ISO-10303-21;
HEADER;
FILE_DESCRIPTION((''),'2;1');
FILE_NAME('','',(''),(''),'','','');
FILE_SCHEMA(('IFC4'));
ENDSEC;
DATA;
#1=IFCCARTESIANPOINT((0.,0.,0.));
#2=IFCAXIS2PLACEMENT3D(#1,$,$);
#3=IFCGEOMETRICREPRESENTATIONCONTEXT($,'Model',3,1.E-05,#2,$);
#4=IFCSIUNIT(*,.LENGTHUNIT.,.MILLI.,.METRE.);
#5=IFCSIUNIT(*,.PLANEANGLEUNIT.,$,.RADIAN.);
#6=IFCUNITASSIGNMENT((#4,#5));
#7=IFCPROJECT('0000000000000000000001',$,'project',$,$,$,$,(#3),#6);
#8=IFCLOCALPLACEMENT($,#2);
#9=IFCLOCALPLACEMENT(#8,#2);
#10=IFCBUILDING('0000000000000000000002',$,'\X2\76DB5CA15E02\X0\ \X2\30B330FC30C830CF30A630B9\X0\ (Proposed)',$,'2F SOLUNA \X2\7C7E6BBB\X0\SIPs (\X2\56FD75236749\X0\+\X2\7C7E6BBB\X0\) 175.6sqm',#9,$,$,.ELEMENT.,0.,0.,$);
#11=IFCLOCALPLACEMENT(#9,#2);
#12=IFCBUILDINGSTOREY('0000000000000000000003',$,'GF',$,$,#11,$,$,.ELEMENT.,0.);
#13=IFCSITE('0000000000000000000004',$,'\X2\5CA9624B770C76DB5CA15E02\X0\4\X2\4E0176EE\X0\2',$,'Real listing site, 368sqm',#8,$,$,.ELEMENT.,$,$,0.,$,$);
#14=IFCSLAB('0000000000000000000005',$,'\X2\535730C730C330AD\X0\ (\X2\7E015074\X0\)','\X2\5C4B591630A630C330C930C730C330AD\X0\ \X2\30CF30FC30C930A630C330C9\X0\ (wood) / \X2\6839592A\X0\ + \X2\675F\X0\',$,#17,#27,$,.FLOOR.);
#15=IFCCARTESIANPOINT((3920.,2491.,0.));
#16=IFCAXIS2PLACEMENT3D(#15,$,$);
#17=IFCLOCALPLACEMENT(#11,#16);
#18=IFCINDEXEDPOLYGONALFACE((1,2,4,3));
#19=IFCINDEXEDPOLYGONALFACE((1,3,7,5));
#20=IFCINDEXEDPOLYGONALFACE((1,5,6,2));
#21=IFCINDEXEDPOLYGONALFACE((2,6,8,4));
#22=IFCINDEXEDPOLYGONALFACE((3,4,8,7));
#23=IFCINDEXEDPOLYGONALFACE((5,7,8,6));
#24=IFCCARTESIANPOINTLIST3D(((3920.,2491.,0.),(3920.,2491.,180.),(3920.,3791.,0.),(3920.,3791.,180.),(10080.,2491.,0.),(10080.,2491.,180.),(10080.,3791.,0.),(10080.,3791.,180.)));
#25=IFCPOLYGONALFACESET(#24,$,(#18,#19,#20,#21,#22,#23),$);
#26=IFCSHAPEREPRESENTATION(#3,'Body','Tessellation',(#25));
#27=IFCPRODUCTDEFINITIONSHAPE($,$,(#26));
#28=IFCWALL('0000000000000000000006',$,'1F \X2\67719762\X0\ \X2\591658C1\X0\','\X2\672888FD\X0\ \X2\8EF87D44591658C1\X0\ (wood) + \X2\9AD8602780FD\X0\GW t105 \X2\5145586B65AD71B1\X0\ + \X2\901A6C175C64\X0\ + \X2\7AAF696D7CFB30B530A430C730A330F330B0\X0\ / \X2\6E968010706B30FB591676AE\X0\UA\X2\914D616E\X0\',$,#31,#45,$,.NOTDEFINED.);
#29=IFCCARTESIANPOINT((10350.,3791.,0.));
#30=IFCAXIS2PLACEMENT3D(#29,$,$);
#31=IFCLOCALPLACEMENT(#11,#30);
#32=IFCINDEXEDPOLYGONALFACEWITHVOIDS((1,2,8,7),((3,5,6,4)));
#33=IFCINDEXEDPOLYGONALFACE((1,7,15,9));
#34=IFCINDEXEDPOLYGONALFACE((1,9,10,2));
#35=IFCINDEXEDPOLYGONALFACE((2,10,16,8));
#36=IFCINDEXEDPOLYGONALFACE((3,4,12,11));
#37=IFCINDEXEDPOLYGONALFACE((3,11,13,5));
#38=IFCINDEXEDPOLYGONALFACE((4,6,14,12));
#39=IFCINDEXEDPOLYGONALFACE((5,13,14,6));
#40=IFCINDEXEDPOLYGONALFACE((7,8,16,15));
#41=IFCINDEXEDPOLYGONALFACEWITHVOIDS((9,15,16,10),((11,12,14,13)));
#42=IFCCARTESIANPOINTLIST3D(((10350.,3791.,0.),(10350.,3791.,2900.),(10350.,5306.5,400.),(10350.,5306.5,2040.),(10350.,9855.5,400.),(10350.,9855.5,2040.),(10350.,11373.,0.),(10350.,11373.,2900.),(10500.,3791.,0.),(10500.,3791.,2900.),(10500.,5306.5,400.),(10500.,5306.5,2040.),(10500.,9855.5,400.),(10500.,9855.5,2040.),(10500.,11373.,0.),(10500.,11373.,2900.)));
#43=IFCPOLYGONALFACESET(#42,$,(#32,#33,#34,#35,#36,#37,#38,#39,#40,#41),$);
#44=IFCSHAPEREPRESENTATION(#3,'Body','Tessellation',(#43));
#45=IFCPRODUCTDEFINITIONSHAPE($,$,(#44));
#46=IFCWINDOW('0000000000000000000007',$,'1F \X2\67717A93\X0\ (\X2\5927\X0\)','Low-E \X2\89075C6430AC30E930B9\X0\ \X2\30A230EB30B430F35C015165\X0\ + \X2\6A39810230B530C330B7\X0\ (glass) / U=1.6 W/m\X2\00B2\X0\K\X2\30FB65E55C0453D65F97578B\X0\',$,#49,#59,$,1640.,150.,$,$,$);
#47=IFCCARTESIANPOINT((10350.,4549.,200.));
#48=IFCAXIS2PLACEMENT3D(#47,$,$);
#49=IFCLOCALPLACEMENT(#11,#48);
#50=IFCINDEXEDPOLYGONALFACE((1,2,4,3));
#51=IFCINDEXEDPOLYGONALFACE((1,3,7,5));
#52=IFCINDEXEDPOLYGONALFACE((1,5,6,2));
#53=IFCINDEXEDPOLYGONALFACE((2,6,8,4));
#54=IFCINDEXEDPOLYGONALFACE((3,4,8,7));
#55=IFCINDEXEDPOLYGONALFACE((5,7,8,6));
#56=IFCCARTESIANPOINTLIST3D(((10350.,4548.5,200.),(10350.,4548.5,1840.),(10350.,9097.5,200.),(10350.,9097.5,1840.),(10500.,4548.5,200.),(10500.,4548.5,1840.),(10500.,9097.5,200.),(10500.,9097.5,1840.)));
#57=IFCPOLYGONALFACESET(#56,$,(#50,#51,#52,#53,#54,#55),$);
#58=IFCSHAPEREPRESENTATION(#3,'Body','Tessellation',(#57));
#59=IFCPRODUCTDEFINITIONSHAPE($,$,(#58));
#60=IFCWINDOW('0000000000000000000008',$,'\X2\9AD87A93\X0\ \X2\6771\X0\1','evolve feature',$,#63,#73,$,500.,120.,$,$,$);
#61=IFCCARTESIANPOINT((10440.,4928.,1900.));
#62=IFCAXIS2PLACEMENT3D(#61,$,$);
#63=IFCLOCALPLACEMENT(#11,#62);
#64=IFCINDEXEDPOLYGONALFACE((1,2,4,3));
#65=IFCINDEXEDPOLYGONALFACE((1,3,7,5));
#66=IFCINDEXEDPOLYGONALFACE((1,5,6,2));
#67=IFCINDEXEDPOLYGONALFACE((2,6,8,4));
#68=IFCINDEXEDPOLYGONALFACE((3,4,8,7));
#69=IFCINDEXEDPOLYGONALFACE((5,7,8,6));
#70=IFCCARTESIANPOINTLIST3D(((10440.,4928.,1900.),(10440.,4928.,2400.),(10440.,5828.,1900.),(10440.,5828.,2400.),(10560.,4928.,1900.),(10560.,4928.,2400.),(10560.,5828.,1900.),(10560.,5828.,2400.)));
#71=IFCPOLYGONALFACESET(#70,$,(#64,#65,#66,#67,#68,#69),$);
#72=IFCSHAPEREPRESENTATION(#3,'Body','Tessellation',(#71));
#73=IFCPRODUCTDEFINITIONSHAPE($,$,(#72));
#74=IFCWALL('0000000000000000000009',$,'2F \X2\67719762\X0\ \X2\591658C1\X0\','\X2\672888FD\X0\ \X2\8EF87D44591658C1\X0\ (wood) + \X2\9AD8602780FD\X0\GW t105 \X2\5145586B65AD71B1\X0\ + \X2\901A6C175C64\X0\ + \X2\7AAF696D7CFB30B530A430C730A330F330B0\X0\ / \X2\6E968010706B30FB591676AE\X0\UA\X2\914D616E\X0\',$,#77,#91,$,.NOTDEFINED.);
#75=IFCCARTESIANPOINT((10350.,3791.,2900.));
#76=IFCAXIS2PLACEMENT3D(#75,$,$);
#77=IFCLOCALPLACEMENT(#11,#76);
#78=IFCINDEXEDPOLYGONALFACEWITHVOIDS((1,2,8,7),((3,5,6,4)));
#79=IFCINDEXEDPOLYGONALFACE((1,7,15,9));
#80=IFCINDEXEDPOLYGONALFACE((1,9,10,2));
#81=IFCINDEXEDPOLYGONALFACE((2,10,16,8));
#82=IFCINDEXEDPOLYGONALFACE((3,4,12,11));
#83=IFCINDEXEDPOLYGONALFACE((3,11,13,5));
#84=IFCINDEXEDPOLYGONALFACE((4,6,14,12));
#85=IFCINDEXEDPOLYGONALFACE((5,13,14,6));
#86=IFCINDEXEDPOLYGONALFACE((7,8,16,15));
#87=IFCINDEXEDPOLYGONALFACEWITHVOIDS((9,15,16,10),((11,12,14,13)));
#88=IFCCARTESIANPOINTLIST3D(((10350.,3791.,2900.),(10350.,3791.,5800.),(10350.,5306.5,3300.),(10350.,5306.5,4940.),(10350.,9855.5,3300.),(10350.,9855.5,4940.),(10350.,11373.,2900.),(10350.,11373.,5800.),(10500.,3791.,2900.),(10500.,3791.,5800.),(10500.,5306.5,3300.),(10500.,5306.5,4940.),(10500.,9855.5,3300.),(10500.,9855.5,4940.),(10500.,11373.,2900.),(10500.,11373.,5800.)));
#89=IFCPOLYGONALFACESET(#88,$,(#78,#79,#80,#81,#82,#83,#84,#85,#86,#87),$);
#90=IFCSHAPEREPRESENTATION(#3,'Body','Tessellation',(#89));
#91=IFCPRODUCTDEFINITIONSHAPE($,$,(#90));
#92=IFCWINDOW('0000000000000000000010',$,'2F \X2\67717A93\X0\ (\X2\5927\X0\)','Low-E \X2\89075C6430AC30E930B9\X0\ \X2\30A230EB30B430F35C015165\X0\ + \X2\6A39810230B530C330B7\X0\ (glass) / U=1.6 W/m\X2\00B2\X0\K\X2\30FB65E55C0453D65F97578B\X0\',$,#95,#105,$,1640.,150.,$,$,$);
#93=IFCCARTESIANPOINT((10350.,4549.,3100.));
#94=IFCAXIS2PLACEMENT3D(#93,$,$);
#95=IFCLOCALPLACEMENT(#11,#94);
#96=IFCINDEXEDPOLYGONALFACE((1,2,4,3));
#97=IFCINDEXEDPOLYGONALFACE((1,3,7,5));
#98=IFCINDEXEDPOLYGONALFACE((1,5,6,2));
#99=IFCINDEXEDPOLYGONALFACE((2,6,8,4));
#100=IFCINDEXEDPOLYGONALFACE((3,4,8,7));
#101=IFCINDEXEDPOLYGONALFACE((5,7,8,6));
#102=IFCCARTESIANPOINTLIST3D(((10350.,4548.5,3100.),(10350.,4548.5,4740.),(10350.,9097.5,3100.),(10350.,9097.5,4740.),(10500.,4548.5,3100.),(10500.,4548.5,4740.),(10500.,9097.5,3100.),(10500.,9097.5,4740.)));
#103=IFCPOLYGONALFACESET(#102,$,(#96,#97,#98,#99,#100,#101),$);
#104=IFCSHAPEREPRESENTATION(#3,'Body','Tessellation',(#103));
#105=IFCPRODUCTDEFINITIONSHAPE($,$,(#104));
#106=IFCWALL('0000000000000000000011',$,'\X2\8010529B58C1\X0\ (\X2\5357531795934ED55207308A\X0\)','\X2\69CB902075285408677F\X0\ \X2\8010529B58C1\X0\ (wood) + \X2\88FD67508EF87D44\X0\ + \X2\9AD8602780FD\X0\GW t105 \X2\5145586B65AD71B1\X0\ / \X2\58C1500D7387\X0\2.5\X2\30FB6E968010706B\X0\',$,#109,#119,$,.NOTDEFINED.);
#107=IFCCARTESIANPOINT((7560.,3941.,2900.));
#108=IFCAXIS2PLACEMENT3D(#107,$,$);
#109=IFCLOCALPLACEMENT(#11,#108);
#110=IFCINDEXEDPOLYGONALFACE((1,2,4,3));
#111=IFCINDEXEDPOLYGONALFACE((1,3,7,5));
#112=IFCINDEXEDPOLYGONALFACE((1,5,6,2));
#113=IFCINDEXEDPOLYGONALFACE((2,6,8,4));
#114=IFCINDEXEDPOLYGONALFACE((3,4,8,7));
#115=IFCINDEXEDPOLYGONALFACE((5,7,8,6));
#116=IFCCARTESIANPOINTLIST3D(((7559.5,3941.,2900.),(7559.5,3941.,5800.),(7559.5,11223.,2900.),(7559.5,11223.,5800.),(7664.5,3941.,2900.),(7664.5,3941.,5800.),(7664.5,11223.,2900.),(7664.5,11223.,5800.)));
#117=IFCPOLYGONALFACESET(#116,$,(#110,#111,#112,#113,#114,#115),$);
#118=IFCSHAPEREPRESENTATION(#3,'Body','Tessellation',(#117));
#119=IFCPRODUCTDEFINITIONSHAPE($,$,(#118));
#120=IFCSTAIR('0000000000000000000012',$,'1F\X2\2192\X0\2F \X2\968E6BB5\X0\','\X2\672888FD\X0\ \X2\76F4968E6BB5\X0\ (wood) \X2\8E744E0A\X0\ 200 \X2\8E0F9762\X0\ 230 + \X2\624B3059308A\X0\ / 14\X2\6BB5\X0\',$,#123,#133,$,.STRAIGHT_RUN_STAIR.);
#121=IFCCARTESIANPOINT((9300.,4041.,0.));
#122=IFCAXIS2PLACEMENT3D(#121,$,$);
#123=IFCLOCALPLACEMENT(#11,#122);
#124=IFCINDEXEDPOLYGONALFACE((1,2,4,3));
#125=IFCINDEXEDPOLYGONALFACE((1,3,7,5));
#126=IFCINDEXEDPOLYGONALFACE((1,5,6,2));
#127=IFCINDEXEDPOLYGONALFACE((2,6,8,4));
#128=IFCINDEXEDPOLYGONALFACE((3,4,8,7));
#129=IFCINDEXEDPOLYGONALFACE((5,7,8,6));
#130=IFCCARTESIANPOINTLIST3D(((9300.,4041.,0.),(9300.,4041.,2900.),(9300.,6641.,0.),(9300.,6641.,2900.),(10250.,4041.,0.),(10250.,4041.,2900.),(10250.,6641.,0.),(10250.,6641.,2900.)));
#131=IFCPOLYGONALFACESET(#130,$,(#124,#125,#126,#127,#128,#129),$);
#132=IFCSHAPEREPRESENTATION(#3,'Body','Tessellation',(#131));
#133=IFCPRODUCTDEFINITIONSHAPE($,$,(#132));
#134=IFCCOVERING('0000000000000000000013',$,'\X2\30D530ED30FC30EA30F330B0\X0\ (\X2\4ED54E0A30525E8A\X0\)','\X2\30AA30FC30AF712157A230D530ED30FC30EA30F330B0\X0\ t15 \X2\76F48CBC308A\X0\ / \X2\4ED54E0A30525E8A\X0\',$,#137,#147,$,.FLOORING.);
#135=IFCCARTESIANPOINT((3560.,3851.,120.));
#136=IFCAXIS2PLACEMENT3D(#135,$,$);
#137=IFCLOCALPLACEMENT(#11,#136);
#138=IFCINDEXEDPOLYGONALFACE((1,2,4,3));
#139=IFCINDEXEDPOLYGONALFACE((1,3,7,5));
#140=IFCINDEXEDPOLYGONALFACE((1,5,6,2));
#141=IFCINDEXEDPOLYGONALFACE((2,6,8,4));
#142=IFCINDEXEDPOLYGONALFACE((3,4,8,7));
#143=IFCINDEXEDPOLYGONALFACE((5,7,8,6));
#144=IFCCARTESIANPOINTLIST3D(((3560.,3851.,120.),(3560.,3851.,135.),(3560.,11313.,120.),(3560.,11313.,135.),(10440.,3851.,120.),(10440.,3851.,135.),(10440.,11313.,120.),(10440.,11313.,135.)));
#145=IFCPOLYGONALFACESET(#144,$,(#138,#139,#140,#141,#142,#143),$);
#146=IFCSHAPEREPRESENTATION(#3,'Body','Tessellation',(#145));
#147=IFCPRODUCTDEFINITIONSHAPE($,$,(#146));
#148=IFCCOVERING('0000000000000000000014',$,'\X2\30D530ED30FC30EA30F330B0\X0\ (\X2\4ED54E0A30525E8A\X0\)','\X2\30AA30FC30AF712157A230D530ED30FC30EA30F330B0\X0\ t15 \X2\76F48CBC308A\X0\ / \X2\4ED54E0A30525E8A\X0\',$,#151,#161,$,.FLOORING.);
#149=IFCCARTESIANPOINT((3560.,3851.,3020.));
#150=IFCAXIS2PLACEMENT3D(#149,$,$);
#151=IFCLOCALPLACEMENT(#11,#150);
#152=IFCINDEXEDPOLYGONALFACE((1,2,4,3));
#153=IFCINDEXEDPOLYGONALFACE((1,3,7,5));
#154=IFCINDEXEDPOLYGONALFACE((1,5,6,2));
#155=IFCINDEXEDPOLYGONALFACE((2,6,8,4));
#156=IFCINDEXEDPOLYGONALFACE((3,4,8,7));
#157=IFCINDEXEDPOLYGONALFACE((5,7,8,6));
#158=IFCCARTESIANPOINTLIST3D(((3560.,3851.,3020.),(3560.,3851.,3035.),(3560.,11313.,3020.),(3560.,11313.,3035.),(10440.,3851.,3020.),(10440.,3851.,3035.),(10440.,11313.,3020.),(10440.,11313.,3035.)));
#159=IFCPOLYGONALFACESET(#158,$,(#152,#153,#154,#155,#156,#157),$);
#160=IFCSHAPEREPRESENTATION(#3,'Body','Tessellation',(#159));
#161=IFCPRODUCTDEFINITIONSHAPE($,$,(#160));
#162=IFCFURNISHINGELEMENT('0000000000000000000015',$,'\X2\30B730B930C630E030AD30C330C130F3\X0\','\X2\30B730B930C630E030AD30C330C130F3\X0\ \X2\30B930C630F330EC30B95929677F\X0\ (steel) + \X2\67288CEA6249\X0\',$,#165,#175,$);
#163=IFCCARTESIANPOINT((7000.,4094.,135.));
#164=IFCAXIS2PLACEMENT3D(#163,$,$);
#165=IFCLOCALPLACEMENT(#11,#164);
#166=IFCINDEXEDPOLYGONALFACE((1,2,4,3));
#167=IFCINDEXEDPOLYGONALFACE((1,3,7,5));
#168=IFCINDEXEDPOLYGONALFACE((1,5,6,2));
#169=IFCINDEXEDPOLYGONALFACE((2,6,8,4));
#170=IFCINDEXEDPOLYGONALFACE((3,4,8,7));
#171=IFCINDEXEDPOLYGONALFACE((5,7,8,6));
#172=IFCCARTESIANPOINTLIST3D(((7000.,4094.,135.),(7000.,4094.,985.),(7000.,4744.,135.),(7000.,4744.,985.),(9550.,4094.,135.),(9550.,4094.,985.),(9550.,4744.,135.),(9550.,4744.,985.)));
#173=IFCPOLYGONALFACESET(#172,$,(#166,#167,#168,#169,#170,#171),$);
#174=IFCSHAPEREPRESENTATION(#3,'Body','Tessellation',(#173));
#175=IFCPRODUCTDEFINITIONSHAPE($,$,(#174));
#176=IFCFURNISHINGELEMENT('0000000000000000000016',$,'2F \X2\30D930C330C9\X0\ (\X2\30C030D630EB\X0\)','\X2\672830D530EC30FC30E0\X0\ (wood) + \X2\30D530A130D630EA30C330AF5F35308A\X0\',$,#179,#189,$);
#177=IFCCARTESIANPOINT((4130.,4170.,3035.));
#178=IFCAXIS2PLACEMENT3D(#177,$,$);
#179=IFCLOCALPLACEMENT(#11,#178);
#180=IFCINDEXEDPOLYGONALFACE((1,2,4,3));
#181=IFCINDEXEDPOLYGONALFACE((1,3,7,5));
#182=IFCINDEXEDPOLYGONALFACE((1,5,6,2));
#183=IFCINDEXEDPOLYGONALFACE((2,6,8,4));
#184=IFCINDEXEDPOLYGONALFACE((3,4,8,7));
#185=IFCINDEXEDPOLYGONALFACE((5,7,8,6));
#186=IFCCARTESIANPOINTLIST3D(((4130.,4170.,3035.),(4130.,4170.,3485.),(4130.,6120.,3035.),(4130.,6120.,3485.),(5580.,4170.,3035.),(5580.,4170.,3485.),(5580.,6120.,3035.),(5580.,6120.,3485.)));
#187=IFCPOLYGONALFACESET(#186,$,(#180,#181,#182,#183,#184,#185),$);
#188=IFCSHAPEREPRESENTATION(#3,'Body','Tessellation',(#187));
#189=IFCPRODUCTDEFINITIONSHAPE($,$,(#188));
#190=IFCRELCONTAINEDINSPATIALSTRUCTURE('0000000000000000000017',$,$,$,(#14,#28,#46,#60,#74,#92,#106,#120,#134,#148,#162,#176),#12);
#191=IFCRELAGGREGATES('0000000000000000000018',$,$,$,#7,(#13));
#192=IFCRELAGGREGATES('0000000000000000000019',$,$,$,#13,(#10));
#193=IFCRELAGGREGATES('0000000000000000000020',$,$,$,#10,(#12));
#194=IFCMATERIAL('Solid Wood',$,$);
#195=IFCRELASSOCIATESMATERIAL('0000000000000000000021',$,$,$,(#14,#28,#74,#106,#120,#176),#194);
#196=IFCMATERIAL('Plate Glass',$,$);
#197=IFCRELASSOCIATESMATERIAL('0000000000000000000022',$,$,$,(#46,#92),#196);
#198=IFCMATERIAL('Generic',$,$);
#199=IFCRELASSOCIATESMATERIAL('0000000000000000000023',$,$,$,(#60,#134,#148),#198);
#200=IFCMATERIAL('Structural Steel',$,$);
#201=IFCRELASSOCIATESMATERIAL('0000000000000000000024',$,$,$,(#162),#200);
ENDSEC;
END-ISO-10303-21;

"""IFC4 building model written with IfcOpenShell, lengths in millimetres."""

from ifc_helpers import new_model, si_unit, frame, frame_2d, origin, place, context, project, spatial, rectangle, extrude, material, element, fill, save


model = new_model("IFC4")

# Units and contexts
model_context = context("Model", 3, precision=1e-05, world=origin())
ifc_project = project(units=[si_unit("LENGTHUNIT", "METRE", prefix="MILLI"), si_unit("PLANEANGLEUNIT", "RADIAN")], contexts=[model_context])

# Site, building, storey
site_placement = place(None, origin())
site = spatial("IfcSite", under=ifc_project, at=site_placement, Name="岩手県盛岡市4丁目2", ObjectType="Real listing site, 368sqm", CompositionType="ELEMENT", RefElevation=0.0)
building_placement = place(site_placement, origin())
building = spatial("IfcBuilding", under=site, at=building_placement, Name="盛岡市 コートハウス (Proposed)", ObjectType="2F SOLUNA 籾殻SIPs (国産杉+籾殻) 175.6sqm", CompositionType="ELEMENT", ElevationOfRefHeight=0.0, ElevationOfTerrain=0.0)
storey_placement = place(building_placement, origin())
storey = spatial("IfcBuildingStorey", under=building, at=storey_placement, Name="GF", CompositionType="ELEMENT", Elevation=0.0)

# Slab
ifc_material_1 = material(Name="Solid Wood")
slab_placement = place(storey_placement, frame((3920.0, 2491.0, 0.0)))
element("IfcSlab", 1, at=slab_placement, inside=storey, material=ifc_material_1, Name="南デッキ (縁側)", Description="屋外ウッドデッキ ハードウッド (wood) / 根太 + 束", PredefinedType="FLOOR", context=model_context, shape_type="SweptSolid", body=[
    extrude(rectangle(XDim=6160.0, YDim=1300.0, at=frame_2d((3080.0, 650.0))), frame((3920.0, 2491.0, 0.0)), (0.0, 0.0, 1.0), 180.0),
])

# Wall, openings, windows
wall_1_placement = place(storey_placement, frame((10350.0, 3791.0, 0.0)))
wall_1 = element("IfcWall", 2, at=wall_1_placement, inside=storey, material=ifc_material_1, Name="1F 東面 外壁", Description="木製 軸組外壁 (wood) + 高性能GW t105 充填断熱 + 通気層 + 窯業系サイディング / 準耐火・外皮UA配慮", PredefinedType="NOTDEFINED", context=model_context, shape_type="SweptSolid", body=[
    extrude(rectangle(XDim=150.0, YDim=7582.0, at=frame_2d((75.0, 3791.0))), frame((10350.0, 3791.0, 0.0)), (0.0, 0.0, 1.0), 2900.0),
])
opening_1_placement = place(storey_placement, frame((10350.0, 4549.0, 200.0)))
opening_1 = element("IfcOpeningElement", 3, at=opening_1_placement, cuts=wall_1, PredefinedType="NOTDEFINED", context=model_context, shape_type="SweptSolid", body=[
    extrude(rectangle(XDim=150.0, YDim=4549.0, at=frame_2d((75.0, 2274.0))), frame((10350.0, 4549.0, 200.0)), (0.0, 0.0, 1.0), 1640.0),
])
opening_2_placement = place(storey_placement, frame((10440.0, 4928.0, 1900.0)))
opening_2 = element("IfcOpeningElement", 4, at=opening_2_placement, cuts=wall_1, PredefinedType="NOTDEFINED", context=model_context, shape_type="SweptSolid", body=[
    extrude(rectangle(XDim=120.0, YDim=900.0, at=frame_2d((60.0, 450.0))), frame((10440.0, 4928.0, 1900.0)), (0.0, 0.0, 1.0), 500.0),
])
ifc_material_2 = material(Name="Plate Glass")
window_1_placement = place(storey_placement, frame((10350.0, 4549.0, 200.0)))
window_1 = element("IfcWindow", 5, at=window_1_placement, inside=storey, material=ifc_material_2, Name="1F 東窓 (大)", Description="Low-E 複層ガラス アルゴン封入 + 樹脂サッシ (glass) / U=1.6 W/m²K・日射取得型", OverallHeight=1640.0, OverallWidth=150.0, context=model_context, shape_type="SweptSolid", body=[
    extrude(rectangle(XDim=150.0, YDim=4549.0, at=frame_2d((75.0, 2274.0))), frame((10350.0, 4549.0, 200.0)), (0.0, 0.0, 1.0), 1640.0),
])
fill(opening_1, window_1)
ifc_material_3 = material(Name="Generic")
window_2_placement = place(storey_placement, frame((10440.0, 4928.0, 1900.0)))
window_2 = element("IfcWindow", 6, at=window_2_placement, inside=storey, material=ifc_material_3, Name="高窓 東1", Description="evolve feature", OverallHeight=500.0, OverallWidth=120.0, context=model_context, shape_type="SweptSolid", body=[
    extrude(rectangle(XDim=120.0, YDim=900.0, at=frame_2d((60.0, 450.0))), frame((10440.0, 4928.0, 1900.0)), (0.0, 0.0, 1.0), 500.0),
])
fill(opening_2, window_2)

# Wall, opening, window
wall_2_placement = place(storey_placement, frame((10350.0, 3791.0, 2900.0)))
wall_2 = element("IfcWall", 7, at=wall_2_placement, inside=storey, material=ifc_material_1, Name="2F 東面 外壁", Description="木製 軸組外壁 (wood) + 高性能GW t105 充填断熱 + 通気層 + 窯業系サイディング / 準耐火・外皮UA配慮", PredefinedType="NOTDEFINED", context=model_context, shape_type="SweptSolid", body=[
    extrude(rectangle(XDim=150.0, YDim=7582.0, at=frame_2d((75.0, 3791.0))), frame((10350.0, 3791.0, 2900.0)), (0.0, 0.0, 1.0), 2900.0),
])
opening_3_placement = place(storey_placement, frame((10350.0, 4549.0, 3100.0)))
opening_3 = element("IfcOpeningElement", 8, at=opening_3_placement, cuts=wall_2, PredefinedType="NOTDEFINED", context=model_context, shape_type="SweptSolid", body=[
    extrude(rectangle(XDim=150.0, YDim=4549.0, at=frame_2d((75.0, 2274.0))), frame((10350.0, 4549.0, 3100.0)), (0.0, 0.0, 1.0), 1640.0),
])
window_3_placement = place(storey_placement, frame((10350.0, 4549.0, 3100.0)))
window_3 = element("IfcWindow", 9, at=window_3_placement, inside=storey, material=ifc_material_2, Name="2F 東窓 (大)", Description="Low-E 複層ガラス アルゴン封入 + 樹脂サッシ (glass) / U=1.6 W/m²K・日射取得型", OverallHeight=1640.0, OverallWidth=150.0, context=model_context, shape_type="SweptSolid", body=[
    extrude(rectangle(XDim=150.0, YDim=4549.0, at=frame_2d((75.0, 2274.0))), frame((10350.0, 4549.0, 3100.0)), (0.0, 0.0, 1.0), 1640.0),
])
fill(opening_3, window_3)

# Wall
wall_3_placement = place(storey_placement, frame((7560.0, 3941.0, 2900.0)))
element("IfcWall", 10, at=wall_3_placement, inside=storey, material=ifc_material_1, Name="耐力壁 (南北間仕切り)", Description="構造用合板 耐力壁 (wood) + 製材軸組 + 高性能GW t105 充填断熱 / 壁倍率2.5・準耐火", PredefinedType="NOTDEFINED", context=model_context, shape_type="SweptSolid", body=[
    extrude(rectangle(XDim=105.0, YDim=7282.0, at=frame_2d((52.0, 3641.0))), frame((7560.0, 3941.0, 2900.0)), (0.0, 0.0, 1.0), 2900.0),
])

# Stair
stair_placement = place(storey_placement, frame((9300.0, 4041.0, 0.0)))
element("IfcStair", 11, at=stair_placement, inside=storey, material=ifc_material_1, Name="1F→2F 階段", Description="木製 直階段 (wood) 蹴上 200 踏面 230 + 手すり / 14段", PredefinedType="STRAIGHT_RUN_STAIR", context=model_context, shape_type="SweptSolid", body=[
    extrude(rectangle(XDim=950.0, YDim=2600.0, at=frame_2d((475.0, 1300.0))), frame((9300.0, 4041.0, 0.0)), (0.0, 0.0, 1.0), 2900.0),
])

# Coverings
covering_1_placement = place(storey_placement, frame((3560.0, 3851.0, 120.0)))
element("IfcCovering", 12, at=covering_1_placement, inside=storey, material=ifc_material_3, Name="フローリング (仕上げ床)", Description="オーク無垢フローリング t15 直貼り / 仕上げ床", PredefinedType="FLOORING", context=model_context, shape_type="SweptSolid", body=[
    extrude(rectangle(XDim=6880.0, YDim=7462.0, at=frame_2d((3440.0, 3731.0))), frame((3560.0, 3851.0, 120.0)), (0.0, 0.0, 1.0), 15.0),
])
covering_2_placement = place(storey_placement, frame((3560.0, 3851.0, 3020.0)))
element("IfcCovering", 13, at=covering_2_placement, inside=storey, material=ifc_material_3, Name="フローリング (仕上げ床)", Description="オーク無垢フローリング t15 直貼り / 仕上げ床", PredefinedType="FLOORING", context=model_context, shape_type="SweptSolid", body=[
    extrude(rectangle(XDim=6880.0, YDim=7462.0, at=frame_2d((3440.0, 3731.0))), frame((3560.0, 3851.0, 3020.0)), (0.0, 0.0, 1.0), 15.0),
])

# Furnishing elements
ifc_material_4 = material(Name="Structural Steel")
furnishing_1_placement = place(storey_placement, frame((7000.0, 4094.0, 135.0)))
element("IfcFurnishingElement", 14, at=furnishing_1_placement, inside=storey, material=ifc_material_4, Name="システムキッチン", Description="システムキッチン ステンレス天板 (steel) + 木質扉", context=model_context, shape_type="SweptSolid", body=[
    extrude(rectangle(XDim=2550.0, YDim=650.0, at=frame_2d((1275.0, 325.0))), frame((7000.0, 4094.0, 135.0)), (0.0, 0.0, 1.0), 850.0),
])
furnishing_2_placement = place(storey_placement, frame((4130.0, 4170.0, 3035.0)))
element("IfcFurnishingElement", 15, at=furnishing_2_placement, inside=storey, material=ifc_material_1, Name="2F ベッド (ダブル)", Description="木フレーム (wood) + ファブリック張り", context=model_context, shape_type="SweptSolid", body=[
    extrude(rectangle(XDim=1450.0, YDim=1950.0, at=frame_2d((725.0, 975.0))), frame((4130.0, 4170.0, 3035.0)), (0.0, 0.0, 1.0), 450.0),
])

save(model, "model.ifc")
